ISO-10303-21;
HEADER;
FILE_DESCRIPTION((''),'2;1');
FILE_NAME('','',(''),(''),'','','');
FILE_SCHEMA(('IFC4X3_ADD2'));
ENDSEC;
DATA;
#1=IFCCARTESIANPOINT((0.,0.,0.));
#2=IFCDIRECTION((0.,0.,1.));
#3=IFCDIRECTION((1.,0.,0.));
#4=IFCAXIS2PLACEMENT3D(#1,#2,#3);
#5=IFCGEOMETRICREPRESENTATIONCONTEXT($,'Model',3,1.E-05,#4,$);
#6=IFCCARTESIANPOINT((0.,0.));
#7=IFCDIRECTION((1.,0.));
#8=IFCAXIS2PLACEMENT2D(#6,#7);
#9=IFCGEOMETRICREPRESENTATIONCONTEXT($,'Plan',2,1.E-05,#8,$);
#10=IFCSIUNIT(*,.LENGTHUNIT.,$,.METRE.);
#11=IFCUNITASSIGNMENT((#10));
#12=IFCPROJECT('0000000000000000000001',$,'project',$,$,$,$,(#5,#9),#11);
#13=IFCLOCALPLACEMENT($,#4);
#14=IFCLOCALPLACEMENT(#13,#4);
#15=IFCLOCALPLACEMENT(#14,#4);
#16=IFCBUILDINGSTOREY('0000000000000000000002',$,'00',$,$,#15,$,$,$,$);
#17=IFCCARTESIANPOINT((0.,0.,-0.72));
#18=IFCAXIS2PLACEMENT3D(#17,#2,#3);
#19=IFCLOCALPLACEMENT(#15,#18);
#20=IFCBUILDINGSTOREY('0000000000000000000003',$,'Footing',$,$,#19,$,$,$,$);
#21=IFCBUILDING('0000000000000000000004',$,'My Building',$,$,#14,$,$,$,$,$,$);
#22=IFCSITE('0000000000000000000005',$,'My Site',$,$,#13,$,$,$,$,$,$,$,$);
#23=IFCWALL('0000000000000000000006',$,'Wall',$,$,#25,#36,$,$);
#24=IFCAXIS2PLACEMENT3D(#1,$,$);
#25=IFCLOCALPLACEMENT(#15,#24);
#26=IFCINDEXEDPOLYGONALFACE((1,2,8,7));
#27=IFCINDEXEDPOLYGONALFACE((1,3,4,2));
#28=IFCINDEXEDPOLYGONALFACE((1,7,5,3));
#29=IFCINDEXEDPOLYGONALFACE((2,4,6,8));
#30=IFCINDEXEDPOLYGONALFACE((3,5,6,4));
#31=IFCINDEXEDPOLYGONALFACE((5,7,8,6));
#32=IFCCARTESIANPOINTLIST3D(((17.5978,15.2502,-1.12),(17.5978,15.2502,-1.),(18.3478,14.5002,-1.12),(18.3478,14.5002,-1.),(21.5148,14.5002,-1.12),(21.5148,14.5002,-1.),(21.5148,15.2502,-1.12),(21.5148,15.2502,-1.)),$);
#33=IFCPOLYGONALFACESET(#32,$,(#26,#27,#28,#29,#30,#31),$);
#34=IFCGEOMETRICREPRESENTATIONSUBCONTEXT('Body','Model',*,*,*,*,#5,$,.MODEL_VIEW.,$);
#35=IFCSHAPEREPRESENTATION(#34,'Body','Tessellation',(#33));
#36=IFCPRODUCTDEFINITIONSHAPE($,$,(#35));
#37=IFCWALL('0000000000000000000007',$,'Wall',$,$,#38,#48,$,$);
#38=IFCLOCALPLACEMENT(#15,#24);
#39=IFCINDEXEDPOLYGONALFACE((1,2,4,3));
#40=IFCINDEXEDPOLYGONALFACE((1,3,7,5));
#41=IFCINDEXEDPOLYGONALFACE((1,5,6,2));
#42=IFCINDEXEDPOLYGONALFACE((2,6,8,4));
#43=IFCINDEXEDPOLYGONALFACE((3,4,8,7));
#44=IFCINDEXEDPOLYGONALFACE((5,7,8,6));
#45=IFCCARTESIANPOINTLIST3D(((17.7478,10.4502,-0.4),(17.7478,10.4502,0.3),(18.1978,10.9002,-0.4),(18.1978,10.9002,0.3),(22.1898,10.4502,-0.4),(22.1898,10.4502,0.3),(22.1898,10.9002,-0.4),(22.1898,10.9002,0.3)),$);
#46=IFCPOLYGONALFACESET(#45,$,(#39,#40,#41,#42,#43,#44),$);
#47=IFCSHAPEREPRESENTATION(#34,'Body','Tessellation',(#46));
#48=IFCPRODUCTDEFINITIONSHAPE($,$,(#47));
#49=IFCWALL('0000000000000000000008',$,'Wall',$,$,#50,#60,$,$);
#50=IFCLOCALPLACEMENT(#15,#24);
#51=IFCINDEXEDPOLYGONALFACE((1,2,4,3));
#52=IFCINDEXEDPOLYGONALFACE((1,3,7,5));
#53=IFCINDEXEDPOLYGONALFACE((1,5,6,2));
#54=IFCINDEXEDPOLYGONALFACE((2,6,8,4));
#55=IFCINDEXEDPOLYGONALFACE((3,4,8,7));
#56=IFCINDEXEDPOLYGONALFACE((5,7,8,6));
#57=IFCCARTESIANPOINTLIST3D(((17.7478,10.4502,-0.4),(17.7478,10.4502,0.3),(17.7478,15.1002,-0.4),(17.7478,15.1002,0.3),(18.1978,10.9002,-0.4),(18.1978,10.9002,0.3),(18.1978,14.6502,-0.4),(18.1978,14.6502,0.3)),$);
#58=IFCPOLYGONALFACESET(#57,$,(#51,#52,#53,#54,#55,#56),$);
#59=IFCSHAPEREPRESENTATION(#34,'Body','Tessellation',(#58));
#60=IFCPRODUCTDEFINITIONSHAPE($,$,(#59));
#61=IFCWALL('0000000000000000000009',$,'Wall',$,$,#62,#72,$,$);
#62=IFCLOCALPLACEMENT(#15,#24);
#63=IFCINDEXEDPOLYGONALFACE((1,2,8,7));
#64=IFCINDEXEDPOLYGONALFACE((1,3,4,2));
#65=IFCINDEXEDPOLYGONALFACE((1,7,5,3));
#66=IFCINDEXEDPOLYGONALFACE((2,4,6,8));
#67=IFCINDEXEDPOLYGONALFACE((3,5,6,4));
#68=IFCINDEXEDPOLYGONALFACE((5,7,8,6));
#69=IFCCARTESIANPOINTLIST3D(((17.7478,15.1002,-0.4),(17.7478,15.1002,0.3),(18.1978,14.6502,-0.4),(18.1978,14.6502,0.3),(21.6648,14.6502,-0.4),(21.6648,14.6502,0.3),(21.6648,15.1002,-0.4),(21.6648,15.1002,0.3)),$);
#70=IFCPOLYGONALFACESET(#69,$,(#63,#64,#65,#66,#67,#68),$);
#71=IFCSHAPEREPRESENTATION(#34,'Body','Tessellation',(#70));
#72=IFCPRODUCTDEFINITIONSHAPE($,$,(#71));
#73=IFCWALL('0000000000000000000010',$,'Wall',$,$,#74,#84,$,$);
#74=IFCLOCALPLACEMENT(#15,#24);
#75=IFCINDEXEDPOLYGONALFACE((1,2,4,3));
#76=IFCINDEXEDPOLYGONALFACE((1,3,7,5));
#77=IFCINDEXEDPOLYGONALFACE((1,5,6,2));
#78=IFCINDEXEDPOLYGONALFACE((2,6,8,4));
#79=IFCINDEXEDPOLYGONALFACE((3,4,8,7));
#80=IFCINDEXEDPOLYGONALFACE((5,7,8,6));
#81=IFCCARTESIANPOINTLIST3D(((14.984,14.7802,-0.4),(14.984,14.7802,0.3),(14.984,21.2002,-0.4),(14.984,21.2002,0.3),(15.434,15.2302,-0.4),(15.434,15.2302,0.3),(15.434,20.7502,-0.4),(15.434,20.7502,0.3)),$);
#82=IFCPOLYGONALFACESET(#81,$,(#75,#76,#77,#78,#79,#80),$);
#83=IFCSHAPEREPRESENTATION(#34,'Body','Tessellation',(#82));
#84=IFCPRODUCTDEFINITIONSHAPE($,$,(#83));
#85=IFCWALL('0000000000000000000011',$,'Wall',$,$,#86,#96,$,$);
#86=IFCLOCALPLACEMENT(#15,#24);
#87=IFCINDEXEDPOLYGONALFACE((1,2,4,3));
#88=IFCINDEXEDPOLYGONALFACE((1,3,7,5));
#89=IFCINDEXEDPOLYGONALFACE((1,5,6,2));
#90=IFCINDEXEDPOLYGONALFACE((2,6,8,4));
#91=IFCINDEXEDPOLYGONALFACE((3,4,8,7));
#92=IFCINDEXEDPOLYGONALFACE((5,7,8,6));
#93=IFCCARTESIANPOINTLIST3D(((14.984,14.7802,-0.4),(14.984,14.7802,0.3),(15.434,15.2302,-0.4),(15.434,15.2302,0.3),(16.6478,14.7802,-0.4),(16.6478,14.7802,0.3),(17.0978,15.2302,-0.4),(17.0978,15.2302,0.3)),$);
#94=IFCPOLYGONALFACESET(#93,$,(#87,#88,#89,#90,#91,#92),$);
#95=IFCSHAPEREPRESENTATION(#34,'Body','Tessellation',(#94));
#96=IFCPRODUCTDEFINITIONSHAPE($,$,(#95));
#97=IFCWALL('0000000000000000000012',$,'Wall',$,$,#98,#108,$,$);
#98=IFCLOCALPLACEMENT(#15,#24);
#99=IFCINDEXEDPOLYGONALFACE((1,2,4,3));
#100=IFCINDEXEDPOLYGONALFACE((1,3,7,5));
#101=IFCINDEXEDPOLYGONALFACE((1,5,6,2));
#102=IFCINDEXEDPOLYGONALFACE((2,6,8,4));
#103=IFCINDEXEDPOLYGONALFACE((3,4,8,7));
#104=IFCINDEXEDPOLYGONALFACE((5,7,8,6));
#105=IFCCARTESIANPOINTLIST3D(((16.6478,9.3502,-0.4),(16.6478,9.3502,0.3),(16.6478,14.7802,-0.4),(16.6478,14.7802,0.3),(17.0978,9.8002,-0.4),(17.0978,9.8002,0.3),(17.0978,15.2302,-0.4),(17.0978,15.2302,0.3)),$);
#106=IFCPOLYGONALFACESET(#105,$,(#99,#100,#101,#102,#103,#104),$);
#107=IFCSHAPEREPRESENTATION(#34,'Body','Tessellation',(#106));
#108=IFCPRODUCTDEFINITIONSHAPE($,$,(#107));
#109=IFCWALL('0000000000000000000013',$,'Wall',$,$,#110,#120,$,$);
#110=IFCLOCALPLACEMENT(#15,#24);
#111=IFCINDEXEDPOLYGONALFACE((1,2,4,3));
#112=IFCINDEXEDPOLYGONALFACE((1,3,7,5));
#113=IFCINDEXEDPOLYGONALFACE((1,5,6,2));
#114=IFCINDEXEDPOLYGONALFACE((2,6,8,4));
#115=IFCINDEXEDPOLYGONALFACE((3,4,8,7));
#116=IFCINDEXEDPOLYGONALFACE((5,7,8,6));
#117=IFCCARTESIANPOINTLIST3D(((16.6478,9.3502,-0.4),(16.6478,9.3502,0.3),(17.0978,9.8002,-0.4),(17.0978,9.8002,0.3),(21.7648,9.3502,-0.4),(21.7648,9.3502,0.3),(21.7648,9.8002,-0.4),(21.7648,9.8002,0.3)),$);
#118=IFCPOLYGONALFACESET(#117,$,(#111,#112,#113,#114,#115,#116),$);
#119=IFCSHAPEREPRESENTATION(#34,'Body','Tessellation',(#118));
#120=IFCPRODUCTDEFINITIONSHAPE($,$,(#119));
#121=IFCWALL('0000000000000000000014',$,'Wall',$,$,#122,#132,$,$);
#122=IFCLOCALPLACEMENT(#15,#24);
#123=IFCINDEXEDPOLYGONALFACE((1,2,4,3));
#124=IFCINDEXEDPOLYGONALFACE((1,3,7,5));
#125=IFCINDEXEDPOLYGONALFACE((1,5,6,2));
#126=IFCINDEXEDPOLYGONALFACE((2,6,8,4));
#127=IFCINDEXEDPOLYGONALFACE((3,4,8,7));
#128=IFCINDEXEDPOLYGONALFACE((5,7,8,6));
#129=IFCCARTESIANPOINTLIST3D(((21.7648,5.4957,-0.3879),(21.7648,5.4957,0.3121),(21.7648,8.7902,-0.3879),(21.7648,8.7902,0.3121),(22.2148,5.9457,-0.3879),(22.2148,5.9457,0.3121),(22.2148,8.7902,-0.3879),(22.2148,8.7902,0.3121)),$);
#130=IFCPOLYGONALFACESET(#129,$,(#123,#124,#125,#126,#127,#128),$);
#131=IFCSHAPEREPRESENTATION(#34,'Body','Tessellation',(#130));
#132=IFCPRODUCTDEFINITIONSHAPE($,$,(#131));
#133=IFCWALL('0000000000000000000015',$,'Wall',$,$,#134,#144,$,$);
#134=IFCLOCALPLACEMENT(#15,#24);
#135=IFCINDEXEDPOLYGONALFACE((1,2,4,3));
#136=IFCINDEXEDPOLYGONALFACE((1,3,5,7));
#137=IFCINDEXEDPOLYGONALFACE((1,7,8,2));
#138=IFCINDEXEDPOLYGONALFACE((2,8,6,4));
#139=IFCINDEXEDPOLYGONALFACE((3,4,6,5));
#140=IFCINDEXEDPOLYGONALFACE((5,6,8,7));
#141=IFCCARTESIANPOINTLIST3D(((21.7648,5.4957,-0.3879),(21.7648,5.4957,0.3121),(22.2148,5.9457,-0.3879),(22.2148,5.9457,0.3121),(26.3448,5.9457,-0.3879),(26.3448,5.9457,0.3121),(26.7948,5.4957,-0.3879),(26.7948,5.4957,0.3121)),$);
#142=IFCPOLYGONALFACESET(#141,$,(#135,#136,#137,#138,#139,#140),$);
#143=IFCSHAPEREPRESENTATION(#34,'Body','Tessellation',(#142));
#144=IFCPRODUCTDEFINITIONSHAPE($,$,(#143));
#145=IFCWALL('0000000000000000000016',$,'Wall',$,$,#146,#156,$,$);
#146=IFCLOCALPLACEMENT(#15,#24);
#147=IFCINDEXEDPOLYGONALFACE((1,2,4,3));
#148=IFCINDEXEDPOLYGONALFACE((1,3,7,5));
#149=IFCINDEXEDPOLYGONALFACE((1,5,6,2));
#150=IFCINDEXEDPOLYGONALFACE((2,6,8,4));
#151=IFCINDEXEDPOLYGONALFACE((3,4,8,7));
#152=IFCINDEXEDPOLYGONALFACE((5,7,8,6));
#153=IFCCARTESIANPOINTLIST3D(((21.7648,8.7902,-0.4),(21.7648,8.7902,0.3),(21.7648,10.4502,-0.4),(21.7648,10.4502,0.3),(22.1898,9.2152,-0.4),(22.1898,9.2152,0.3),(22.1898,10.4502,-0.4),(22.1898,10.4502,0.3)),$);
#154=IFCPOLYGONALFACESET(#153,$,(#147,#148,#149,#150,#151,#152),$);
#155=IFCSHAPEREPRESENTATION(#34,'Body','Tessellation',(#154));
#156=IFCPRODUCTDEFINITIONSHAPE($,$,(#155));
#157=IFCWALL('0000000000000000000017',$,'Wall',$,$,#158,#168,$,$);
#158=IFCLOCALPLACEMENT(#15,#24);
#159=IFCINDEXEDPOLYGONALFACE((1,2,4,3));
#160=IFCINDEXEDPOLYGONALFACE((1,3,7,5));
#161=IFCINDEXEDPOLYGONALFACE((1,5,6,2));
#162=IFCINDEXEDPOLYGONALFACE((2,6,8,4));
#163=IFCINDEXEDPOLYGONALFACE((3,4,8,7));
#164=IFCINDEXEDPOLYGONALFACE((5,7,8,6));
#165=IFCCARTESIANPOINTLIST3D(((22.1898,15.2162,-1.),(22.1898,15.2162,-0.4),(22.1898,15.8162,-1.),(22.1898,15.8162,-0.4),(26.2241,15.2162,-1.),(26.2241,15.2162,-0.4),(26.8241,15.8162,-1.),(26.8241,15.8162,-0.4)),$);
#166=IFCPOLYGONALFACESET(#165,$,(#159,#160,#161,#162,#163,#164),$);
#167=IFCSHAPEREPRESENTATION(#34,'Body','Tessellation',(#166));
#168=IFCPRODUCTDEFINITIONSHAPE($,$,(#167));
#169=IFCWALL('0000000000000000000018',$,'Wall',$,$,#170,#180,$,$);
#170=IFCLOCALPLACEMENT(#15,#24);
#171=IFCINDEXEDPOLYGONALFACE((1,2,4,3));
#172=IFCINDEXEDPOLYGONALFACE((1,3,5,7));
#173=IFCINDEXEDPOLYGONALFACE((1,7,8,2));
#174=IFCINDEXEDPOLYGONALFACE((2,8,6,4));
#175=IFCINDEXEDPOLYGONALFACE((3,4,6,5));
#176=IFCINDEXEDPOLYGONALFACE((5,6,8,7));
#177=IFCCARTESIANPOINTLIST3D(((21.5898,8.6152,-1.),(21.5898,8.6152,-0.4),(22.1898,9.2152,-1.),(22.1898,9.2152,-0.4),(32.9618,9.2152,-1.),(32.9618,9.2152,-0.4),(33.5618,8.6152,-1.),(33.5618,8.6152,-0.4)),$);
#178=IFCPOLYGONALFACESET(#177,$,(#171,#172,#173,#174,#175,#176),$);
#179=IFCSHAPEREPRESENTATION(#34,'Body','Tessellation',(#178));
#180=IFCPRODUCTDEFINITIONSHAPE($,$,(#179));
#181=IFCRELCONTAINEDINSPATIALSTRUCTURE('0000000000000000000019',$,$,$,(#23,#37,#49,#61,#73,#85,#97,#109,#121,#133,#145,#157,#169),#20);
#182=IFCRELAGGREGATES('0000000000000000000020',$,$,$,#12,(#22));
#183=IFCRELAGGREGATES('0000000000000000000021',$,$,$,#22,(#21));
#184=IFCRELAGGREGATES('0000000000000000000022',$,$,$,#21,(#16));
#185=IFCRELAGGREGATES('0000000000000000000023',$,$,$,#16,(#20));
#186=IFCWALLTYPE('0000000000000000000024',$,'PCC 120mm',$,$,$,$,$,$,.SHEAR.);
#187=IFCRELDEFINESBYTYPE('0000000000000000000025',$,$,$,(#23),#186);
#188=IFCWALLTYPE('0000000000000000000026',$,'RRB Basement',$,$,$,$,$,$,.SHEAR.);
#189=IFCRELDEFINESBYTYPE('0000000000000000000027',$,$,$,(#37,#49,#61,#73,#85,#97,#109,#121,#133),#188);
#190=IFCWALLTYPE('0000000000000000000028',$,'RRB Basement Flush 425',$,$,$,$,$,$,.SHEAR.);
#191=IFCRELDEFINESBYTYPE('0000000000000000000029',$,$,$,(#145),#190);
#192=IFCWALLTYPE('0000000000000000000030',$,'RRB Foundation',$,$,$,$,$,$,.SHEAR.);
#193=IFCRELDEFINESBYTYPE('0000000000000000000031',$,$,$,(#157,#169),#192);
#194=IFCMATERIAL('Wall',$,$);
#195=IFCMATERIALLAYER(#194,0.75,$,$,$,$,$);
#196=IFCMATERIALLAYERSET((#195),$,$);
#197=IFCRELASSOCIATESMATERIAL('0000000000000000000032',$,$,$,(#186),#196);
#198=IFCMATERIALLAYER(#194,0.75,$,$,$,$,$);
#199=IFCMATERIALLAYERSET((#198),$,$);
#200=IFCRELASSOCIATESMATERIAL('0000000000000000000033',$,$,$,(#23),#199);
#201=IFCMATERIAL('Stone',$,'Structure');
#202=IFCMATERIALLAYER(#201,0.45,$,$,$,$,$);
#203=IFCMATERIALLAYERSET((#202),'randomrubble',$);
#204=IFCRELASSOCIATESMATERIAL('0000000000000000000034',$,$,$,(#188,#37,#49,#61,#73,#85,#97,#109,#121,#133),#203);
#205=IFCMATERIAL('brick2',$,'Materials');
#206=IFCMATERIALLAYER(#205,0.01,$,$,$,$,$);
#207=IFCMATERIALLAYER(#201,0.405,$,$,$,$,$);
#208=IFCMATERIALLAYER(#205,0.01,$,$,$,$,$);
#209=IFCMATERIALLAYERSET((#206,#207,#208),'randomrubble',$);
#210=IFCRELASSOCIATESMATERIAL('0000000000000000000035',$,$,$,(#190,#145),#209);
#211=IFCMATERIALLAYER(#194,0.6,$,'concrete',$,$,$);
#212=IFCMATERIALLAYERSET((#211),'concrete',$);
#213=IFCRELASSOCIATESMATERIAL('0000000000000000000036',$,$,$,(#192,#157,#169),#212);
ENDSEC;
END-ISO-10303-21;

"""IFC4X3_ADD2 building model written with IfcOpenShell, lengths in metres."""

from ifc_helpers import new_model, si_unit, frame, origin_with_axes, origin_2d_with_axis, place, context, subcontext, project, spatial, line, indexed_curve, outline, extrude, material, layer, layer_set, layer_usage, type_object, element, save


model = new_model("IFC4X3_ADD2")

# Units and contexts
model_context = context("Model", 3, precision=1e-05, world=origin_with_axes())
plan_context = context("Plan", 2, precision=1e-05, world=origin_2d_with_axis())
body_context = subcontext(model_context, "Body", "Model", "MODEL_VIEW")
ifc_project = project(units=[si_unit("LENGTHUNIT", "METRE")], contexts=[model_context, plan_context])

# Site, building, storeys
site_placement = place(None, origin_with_axes())
site = spatial("IfcSite", under=ifc_project, at=site_placement, Name="My Site")
building_placement = place(site_placement, origin_with_axes())
building = spatial("IfcBuilding", under=site, at=building_placement, Name="My Building")
storey_1_placement = place(building_placement, origin_with_axes())
storey_1 = spatial("IfcBuildingStorey", under=building, at=storey_1_placement, Name="00")
storey_2_placement = place(storey_1_placement, frame((0.0, 0.0, -0.72), z_axis=(0.0, 0.0, 1.0), x_axis=(1.0, 0.0, 0.0)))
storey_2 = spatial("IfcBuildingStorey", under=storey_1, at=storey_2_placement, Name="Footing")

# Shared definitions
ifc_material_1 = material(Name="brick2", Category="Materials")
ifc_material_2 = material(Name="Stone", Category="Structure")

# Walls
ifc_material_3 = material(Name="Wall")
ifc_layer_1 = layer(ifc_material_3, 0.75)
ifc_layer_set_1 = layer_set([ifc_layer_1])
ifc_layer_2 = layer(ifc_material_3, 0.75)
ifc_layer_set_2 = layer_set([ifc_layer_2])
wall_type_1 = type_object("IfcWallType", Name="PCC 120mm", PredefinedType="SHEAR", material=ifc_layer_set_2)
ifc_layer_usage_1 = layer_usage(ifc_layer_set_1, "AXIS2", "POSITIVE", 0.0)
wall_1_placement = place(storey_2_placement, frame((18.3478, 14.5002, -0.4), z_axis=(0.0, 0.0, 1.0), x_axis=(1.0, 0.0, 0.0)))
element("IfcWall", 1, at=wall_1_placement, inside=storey_2, type_object=wall_type_1, material=ifc_layer_usage_1, Name="Wall", context=body_context, shape_type="SweptSolid", body=[
    extrude(outline(indexed_curve([(0.0, 0.0), (-0.75, 0.75), (3.167, 0.75), (3.167, 0.0)], segments=[line(1, 2, 3, 4, 1)])), origin_with_axes(), (0.0, 0.0, 1.0), 0.12),
])
ifc_layer_3 = layer(ifc_material_2, 0.45)
ifc_layer_set_3 = layer_set([ifc_layer_3], Name="randomrubble")
ifc_layer_usage_2 = layer_usage(ifc_layer_set_3, "AXIS2", "POSITIVE", 0.0)
wall_type_2 = type_object("IfcWallType", Name="RRB Basement", PredefinedType="SHEAR", material=ifc_layer_set_3)
wall_2_placement = place(storey_2_placement, frame((18.1978, 10.4502, 0.32), z_axis=(0.0, 0.0, 1.0), x_axis=(1.0, 0.0, 0.0)))
element("IfcWall", 2, at=wall_2_placement, inside=storey_2, type_object=wall_type_2, material=ifc_layer_usage_2, Name="Wall", context=body_context, shape_type="SweptSolid", body=[
    extrude(outline(indexed_curve([(-0.45, 0.0), (0.0, 0.45), (3.992, 0.45), (3.992, 0.0)], segments=[line(1, 2, 3, 4, 1)])), origin_with_axes(), (0.0, 0.0, 1.0), 0.7),
])
ifc_layer_usage_3 = layer_usage(ifc_layer_set_3, "AXIS2", "POSITIVE", 0.0)
wall_3_placement = place(storey_2_placement, frame((18.1978, 10.4502, 0.32), z_axis=(0.0, 0.0, 1.0), x_axis=(0.000001, 1.0, 0.0)))
element("IfcWall", 3, at=wall_3_placement, inside=storey_2, type_object=wall_type_2, material=ifc_layer_usage_3, Name="Wall", context=body_context, shape_type="SweptSolid", body=[
    extrude(outline(indexed_curve([(0.45, 0.0), (0.0, 0.45), (4.65, 0.45), (4.2, 0.0)], segments=[line(1, 2, 3, 4, 1)])), origin_with_axes(), (0.0, 0.0, 1.0), 0.7),
])
ifc_layer_usage_4 = layer_usage(ifc_layer_set_3, "AXIS2", "POSITIVE", 0.0)
wall_4_placement = place(storey_2_placement, frame((18.1978, 14.6502, 0.32), z_axis=(0.0, 0.0, 1.0), x_axis=(1.0, 0.0, 0.0)))
element("IfcWall", 4, at=wall_4_placement, inside=storey_2, type_object=wall_type_2, material=ifc_layer_usage_4, Name="Wall", context=body_context, shape_type="SweptSolid", body=[
    extrude(outline(indexed_curve([(0.0, 0.0), (-0.45, 0.45), (3.467, 0.45), (3.467, 0.0)], segments=[line(1, 2, 3, 4, 1)])), origin_with_axes(), (0.0, 0.0, 1.0), 0.7),
])
ifc_layer_usage_5 = layer_usage(ifc_layer_set_3, "AXIS2", "POSITIVE", 0.0)
wall_5_placement = place(storey_2_placement, frame((15.434, 14.7802, 0.32), z_axis=(0.0, 0.0, 1.0), x_axis=(0.000001, 1.0, 0.0)))
element("IfcWall", 5, at=wall_5_placement, inside=storey_2, type_object=wall_type_2, material=ifc_layer_usage_5, Name="Wall", context=body_context, shape_type="SweptSolid", body=[
    extrude(outline(indexed_curve([(0.45, 0.0), (0.0, 0.45), (6.42, 0.45), (5.97, 0.0)], segments=[line(1, 2, 3, 4, 1)])), origin_with_axes(), (0.0, 0.0, 1.0), 0.7),
])
ifc_layer_usage_6 = layer_usage(ifc_layer_set_3, "AXIS2", "POSITIVE", 0.0)
wall_6_placement = place(storey_2_placement, frame((15.434, 14.7802, 0.32), z_axis=(0.0, 0.0, 1.0), x_axis=(1.0, 0.0, 0.0)))
element("IfcWall", 6, at=wall_6_placement, inside=storey_2, type_object=wall_type_2, material=ifc_layer_usage_6, Name="Wall", context=body_context, shape_type="SweptSolid", body=[
    extrude(outline(indexed_curve([(-0.45, 0.0), (0.0, 0.45), (1.6638, 0.45), (1.2138, 0.0)], segments=[line(1, 2, 3, 4, 1)])), origin_with_axes(), (0.0, 0.0, 1.0), 0.7),
])
ifc_layer_usage_7 = layer_usage(ifc_layer_set_3, "AXIS2", "POSITIVE", 0.0)
wall_7_placement = place(storey_2_placement, frame((17.0978, 9.3502, 0.32), z_axis=(0.0, 0.0, 1.0), x_axis=(0.000001, 1.0, 0.0)))
element("IfcWall", 7, at=wall_7_placement, inside=storey_2, type_object=wall_type_2, material=ifc_layer_usage_7, Name="Wall", context=body_context, shape_type="SweptSolid", body=[
    extrude(outline(indexed_curve([(0.45, 0.0), (0.0, 0.45), (5.43, 0.45), (5.88, 0.0)], segments=[line(1, 2, 3, 4, 1)])), origin_with_axes(), (0.0, 0.0, 1.0), 0.7),
])
ifc_layer_usage_8 = layer_usage(ifc_layer_set_3, "AXIS2", "POSITIVE", 0.0)
wall_8_placement = place(storey_2_placement, frame((17.0978, 9.3502, 0.32), z_axis=(0.0, 0.0, 1.0), x_axis=(1.0, 0.0, 0.0)))
element("IfcWall", 8, at=wall_8_placement, inside=storey_2, type_object=wall_type_2, material=ifc_layer_usage_8, Name="Wall", context=body_context, shape_type="SweptSolid", body=[
    extrude(outline(indexed_curve([(-0.45, 0.0), (0.0, 0.45), (4.667, 0.45), (4.667, 0.0)], segments=[line(1, 2, 3, 4, 1)])), origin_with_axes(), (0.0, 0.0, 1.0), 0.7),
])
ifc_layer_usage_9 = layer_usage(ifc_layer_set_3, "AXIS2", "POSITIVE", 0.0)
wall_9_placement = place(storey_2_placement, frame((22.2148, 5.4957, 0.3321), z_axis=(0.0, 0.0, 1.0), x_axis=(0.000001, 1.0, 0.0)))
element("IfcWall", 9, at=wall_9_placement, inside=storey_2, type_object=wall_type_2, material=ifc_layer_usage_9, Name="Wall", context=body_context, shape_type="SweptSolid", body=[
    extrude(outline(indexed_curve([(0.45, 0.0), (0.0, 0.45), (3.2945, 0.45), (3.2945, 0.0)], segments=[line(1, 2, 3, 4, 1)])), origin_with_axes(), (0.0, 0.0, 1.0), 0.7),
])
ifc_layer_usage_10 = layer_usage(ifc_layer_set_3, "AXIS2", "POSITIVE", 0.0)
wall_10_placement = place(storey_2_placement, frame((22.2148, 5.4957, 0.3321), z_axis=(0.0, 0.0, 1.0), x_axis=(1.0, 0.0, 0.0)))
element("IfcWall", 10, at=wall_10_placement, inside=storey_2, type_object=wall_type_2, material=ifc_layer_usage_10, Name="Wall", context=body_context, shape_type="SweptSolid", body=[
    extrude(outline(indexed_curve([(-0.45, 0.0), (0.0, 0.45), (4.13, 0.45), (4.58, 0.0)], segments=[line(1, 2, 3, 4, 1)])), origin_with_axes(), (0.0, 0.0, 1.0), 0.7),
])
ifc_layer_4 = layer(ifc_material_1, 0.01)
ifc_layer_5 = layer(ifc_material_2, 0.405)
ifc_layer_6 = layer(ifc_material_1, 0.01)
ifc_layer_set_4 = layer_set([ifc_layer_4, ifc_layer_5, ifc_layer_6], Name="randomrubble")
ifc_layer_usage_11 = layer_usage(ifc_layer_set_4, "AXIS2", "POSITIVE", 0.0)
wall_type_3 = type_object("IfcWallType", Name="RRB Basement Flush 425", PredefinedType="SHEAR", material=ifc_layer_set_4)
wall_11_placement = place(storey_2_placement, frame((22.1898, 8.7902, 0.32), z_axis=(0.0, 0.0, 1.0), x_axis=(0.0, 1.0, 0.0)))
element("IfcWall", 11, at=wall_11_placement, inside=storey_2, type_object=wall_type_3, material=ifc_layer_usage_11, Name="Wall", context=body_context, shape_type="SweptSolid", body=[
    extrude(outline(indexed_curve([(0.425, 0.0), (0.0, 0.425), (1.66, 0.425), (1.66, 0.0)], segments=[line(1, 2, 3, 4, 1)])), origin_with_axes(), (0.0, 0.0, 1.0), 0.7),
])
ifc_layer_7 = layer(ifc_material_3, 0.6, Name="concrete")
ifc_layer_set_5 = layer_set([ifc_layer_7], Name="concrete")
ifc_layer_usage_12 = layer_usage(ifc_layer_set_5, "AXIS2", "POSITIVE", 0.0)
wall_type_4 = type_object("IfcWallType", Name="RRB Foundation", PredefinedType="SHEAR", material=ifc_layer_set_5)
wall_12_placement = place(storey_2_placement, frame((22.1898, 15.2162, -0.28), z_axis=(0.0, 0.0, 1.0), x_axis=(1.0, 0.0, 0.0)))
element("IfcWall", 12, at=wall_12_placement, inside=storey_2, type_object=wall_type_4, material=ifc_layer_usage_12, Name="Wall", context=body_context, shape_type="SweptSolid", body=[
    extrude(outline(indexed_curve([(0.0, 0.0), (0.0, 0.6), (4.6343, 0.6), (4.0343, 0.0)], segments=[line(1, 2, 3, 4, 1)])), origin_with_axes(), (0.0, 0.0, 1.0), 0.6),
])
ifc_layer_usage_13 = layer_usage(ifc_layer_set_5, "AXIS2", "POSITIVE", 0.0)
wall_13_placement = place(storey_2_placement, frame((22.1898, 8.6152, -0.28), z_axis=(0.0, 0.0, 1.0), x_axis=(1.0, 0.0, 0.0)))
element("IfcWall", 13, at=wall_13_placement, inside=storey_2, type_object=wall_type_4, material=ifc_layer_usage_13, Name="Wall", context=body_context, shape_type="SweptSolid", body=[
    extrude(outline(indexed_curve([(-0.6, 0.0), (0.0, 0.6), (10.772, 0.6), (11.372, 0.0)], segments=[line(1, 2, 3, 4, 1)])), origin_with_axes(), (0.0, 0.0, 1.0), 0.6),
])

save(model, "model.ifc")
